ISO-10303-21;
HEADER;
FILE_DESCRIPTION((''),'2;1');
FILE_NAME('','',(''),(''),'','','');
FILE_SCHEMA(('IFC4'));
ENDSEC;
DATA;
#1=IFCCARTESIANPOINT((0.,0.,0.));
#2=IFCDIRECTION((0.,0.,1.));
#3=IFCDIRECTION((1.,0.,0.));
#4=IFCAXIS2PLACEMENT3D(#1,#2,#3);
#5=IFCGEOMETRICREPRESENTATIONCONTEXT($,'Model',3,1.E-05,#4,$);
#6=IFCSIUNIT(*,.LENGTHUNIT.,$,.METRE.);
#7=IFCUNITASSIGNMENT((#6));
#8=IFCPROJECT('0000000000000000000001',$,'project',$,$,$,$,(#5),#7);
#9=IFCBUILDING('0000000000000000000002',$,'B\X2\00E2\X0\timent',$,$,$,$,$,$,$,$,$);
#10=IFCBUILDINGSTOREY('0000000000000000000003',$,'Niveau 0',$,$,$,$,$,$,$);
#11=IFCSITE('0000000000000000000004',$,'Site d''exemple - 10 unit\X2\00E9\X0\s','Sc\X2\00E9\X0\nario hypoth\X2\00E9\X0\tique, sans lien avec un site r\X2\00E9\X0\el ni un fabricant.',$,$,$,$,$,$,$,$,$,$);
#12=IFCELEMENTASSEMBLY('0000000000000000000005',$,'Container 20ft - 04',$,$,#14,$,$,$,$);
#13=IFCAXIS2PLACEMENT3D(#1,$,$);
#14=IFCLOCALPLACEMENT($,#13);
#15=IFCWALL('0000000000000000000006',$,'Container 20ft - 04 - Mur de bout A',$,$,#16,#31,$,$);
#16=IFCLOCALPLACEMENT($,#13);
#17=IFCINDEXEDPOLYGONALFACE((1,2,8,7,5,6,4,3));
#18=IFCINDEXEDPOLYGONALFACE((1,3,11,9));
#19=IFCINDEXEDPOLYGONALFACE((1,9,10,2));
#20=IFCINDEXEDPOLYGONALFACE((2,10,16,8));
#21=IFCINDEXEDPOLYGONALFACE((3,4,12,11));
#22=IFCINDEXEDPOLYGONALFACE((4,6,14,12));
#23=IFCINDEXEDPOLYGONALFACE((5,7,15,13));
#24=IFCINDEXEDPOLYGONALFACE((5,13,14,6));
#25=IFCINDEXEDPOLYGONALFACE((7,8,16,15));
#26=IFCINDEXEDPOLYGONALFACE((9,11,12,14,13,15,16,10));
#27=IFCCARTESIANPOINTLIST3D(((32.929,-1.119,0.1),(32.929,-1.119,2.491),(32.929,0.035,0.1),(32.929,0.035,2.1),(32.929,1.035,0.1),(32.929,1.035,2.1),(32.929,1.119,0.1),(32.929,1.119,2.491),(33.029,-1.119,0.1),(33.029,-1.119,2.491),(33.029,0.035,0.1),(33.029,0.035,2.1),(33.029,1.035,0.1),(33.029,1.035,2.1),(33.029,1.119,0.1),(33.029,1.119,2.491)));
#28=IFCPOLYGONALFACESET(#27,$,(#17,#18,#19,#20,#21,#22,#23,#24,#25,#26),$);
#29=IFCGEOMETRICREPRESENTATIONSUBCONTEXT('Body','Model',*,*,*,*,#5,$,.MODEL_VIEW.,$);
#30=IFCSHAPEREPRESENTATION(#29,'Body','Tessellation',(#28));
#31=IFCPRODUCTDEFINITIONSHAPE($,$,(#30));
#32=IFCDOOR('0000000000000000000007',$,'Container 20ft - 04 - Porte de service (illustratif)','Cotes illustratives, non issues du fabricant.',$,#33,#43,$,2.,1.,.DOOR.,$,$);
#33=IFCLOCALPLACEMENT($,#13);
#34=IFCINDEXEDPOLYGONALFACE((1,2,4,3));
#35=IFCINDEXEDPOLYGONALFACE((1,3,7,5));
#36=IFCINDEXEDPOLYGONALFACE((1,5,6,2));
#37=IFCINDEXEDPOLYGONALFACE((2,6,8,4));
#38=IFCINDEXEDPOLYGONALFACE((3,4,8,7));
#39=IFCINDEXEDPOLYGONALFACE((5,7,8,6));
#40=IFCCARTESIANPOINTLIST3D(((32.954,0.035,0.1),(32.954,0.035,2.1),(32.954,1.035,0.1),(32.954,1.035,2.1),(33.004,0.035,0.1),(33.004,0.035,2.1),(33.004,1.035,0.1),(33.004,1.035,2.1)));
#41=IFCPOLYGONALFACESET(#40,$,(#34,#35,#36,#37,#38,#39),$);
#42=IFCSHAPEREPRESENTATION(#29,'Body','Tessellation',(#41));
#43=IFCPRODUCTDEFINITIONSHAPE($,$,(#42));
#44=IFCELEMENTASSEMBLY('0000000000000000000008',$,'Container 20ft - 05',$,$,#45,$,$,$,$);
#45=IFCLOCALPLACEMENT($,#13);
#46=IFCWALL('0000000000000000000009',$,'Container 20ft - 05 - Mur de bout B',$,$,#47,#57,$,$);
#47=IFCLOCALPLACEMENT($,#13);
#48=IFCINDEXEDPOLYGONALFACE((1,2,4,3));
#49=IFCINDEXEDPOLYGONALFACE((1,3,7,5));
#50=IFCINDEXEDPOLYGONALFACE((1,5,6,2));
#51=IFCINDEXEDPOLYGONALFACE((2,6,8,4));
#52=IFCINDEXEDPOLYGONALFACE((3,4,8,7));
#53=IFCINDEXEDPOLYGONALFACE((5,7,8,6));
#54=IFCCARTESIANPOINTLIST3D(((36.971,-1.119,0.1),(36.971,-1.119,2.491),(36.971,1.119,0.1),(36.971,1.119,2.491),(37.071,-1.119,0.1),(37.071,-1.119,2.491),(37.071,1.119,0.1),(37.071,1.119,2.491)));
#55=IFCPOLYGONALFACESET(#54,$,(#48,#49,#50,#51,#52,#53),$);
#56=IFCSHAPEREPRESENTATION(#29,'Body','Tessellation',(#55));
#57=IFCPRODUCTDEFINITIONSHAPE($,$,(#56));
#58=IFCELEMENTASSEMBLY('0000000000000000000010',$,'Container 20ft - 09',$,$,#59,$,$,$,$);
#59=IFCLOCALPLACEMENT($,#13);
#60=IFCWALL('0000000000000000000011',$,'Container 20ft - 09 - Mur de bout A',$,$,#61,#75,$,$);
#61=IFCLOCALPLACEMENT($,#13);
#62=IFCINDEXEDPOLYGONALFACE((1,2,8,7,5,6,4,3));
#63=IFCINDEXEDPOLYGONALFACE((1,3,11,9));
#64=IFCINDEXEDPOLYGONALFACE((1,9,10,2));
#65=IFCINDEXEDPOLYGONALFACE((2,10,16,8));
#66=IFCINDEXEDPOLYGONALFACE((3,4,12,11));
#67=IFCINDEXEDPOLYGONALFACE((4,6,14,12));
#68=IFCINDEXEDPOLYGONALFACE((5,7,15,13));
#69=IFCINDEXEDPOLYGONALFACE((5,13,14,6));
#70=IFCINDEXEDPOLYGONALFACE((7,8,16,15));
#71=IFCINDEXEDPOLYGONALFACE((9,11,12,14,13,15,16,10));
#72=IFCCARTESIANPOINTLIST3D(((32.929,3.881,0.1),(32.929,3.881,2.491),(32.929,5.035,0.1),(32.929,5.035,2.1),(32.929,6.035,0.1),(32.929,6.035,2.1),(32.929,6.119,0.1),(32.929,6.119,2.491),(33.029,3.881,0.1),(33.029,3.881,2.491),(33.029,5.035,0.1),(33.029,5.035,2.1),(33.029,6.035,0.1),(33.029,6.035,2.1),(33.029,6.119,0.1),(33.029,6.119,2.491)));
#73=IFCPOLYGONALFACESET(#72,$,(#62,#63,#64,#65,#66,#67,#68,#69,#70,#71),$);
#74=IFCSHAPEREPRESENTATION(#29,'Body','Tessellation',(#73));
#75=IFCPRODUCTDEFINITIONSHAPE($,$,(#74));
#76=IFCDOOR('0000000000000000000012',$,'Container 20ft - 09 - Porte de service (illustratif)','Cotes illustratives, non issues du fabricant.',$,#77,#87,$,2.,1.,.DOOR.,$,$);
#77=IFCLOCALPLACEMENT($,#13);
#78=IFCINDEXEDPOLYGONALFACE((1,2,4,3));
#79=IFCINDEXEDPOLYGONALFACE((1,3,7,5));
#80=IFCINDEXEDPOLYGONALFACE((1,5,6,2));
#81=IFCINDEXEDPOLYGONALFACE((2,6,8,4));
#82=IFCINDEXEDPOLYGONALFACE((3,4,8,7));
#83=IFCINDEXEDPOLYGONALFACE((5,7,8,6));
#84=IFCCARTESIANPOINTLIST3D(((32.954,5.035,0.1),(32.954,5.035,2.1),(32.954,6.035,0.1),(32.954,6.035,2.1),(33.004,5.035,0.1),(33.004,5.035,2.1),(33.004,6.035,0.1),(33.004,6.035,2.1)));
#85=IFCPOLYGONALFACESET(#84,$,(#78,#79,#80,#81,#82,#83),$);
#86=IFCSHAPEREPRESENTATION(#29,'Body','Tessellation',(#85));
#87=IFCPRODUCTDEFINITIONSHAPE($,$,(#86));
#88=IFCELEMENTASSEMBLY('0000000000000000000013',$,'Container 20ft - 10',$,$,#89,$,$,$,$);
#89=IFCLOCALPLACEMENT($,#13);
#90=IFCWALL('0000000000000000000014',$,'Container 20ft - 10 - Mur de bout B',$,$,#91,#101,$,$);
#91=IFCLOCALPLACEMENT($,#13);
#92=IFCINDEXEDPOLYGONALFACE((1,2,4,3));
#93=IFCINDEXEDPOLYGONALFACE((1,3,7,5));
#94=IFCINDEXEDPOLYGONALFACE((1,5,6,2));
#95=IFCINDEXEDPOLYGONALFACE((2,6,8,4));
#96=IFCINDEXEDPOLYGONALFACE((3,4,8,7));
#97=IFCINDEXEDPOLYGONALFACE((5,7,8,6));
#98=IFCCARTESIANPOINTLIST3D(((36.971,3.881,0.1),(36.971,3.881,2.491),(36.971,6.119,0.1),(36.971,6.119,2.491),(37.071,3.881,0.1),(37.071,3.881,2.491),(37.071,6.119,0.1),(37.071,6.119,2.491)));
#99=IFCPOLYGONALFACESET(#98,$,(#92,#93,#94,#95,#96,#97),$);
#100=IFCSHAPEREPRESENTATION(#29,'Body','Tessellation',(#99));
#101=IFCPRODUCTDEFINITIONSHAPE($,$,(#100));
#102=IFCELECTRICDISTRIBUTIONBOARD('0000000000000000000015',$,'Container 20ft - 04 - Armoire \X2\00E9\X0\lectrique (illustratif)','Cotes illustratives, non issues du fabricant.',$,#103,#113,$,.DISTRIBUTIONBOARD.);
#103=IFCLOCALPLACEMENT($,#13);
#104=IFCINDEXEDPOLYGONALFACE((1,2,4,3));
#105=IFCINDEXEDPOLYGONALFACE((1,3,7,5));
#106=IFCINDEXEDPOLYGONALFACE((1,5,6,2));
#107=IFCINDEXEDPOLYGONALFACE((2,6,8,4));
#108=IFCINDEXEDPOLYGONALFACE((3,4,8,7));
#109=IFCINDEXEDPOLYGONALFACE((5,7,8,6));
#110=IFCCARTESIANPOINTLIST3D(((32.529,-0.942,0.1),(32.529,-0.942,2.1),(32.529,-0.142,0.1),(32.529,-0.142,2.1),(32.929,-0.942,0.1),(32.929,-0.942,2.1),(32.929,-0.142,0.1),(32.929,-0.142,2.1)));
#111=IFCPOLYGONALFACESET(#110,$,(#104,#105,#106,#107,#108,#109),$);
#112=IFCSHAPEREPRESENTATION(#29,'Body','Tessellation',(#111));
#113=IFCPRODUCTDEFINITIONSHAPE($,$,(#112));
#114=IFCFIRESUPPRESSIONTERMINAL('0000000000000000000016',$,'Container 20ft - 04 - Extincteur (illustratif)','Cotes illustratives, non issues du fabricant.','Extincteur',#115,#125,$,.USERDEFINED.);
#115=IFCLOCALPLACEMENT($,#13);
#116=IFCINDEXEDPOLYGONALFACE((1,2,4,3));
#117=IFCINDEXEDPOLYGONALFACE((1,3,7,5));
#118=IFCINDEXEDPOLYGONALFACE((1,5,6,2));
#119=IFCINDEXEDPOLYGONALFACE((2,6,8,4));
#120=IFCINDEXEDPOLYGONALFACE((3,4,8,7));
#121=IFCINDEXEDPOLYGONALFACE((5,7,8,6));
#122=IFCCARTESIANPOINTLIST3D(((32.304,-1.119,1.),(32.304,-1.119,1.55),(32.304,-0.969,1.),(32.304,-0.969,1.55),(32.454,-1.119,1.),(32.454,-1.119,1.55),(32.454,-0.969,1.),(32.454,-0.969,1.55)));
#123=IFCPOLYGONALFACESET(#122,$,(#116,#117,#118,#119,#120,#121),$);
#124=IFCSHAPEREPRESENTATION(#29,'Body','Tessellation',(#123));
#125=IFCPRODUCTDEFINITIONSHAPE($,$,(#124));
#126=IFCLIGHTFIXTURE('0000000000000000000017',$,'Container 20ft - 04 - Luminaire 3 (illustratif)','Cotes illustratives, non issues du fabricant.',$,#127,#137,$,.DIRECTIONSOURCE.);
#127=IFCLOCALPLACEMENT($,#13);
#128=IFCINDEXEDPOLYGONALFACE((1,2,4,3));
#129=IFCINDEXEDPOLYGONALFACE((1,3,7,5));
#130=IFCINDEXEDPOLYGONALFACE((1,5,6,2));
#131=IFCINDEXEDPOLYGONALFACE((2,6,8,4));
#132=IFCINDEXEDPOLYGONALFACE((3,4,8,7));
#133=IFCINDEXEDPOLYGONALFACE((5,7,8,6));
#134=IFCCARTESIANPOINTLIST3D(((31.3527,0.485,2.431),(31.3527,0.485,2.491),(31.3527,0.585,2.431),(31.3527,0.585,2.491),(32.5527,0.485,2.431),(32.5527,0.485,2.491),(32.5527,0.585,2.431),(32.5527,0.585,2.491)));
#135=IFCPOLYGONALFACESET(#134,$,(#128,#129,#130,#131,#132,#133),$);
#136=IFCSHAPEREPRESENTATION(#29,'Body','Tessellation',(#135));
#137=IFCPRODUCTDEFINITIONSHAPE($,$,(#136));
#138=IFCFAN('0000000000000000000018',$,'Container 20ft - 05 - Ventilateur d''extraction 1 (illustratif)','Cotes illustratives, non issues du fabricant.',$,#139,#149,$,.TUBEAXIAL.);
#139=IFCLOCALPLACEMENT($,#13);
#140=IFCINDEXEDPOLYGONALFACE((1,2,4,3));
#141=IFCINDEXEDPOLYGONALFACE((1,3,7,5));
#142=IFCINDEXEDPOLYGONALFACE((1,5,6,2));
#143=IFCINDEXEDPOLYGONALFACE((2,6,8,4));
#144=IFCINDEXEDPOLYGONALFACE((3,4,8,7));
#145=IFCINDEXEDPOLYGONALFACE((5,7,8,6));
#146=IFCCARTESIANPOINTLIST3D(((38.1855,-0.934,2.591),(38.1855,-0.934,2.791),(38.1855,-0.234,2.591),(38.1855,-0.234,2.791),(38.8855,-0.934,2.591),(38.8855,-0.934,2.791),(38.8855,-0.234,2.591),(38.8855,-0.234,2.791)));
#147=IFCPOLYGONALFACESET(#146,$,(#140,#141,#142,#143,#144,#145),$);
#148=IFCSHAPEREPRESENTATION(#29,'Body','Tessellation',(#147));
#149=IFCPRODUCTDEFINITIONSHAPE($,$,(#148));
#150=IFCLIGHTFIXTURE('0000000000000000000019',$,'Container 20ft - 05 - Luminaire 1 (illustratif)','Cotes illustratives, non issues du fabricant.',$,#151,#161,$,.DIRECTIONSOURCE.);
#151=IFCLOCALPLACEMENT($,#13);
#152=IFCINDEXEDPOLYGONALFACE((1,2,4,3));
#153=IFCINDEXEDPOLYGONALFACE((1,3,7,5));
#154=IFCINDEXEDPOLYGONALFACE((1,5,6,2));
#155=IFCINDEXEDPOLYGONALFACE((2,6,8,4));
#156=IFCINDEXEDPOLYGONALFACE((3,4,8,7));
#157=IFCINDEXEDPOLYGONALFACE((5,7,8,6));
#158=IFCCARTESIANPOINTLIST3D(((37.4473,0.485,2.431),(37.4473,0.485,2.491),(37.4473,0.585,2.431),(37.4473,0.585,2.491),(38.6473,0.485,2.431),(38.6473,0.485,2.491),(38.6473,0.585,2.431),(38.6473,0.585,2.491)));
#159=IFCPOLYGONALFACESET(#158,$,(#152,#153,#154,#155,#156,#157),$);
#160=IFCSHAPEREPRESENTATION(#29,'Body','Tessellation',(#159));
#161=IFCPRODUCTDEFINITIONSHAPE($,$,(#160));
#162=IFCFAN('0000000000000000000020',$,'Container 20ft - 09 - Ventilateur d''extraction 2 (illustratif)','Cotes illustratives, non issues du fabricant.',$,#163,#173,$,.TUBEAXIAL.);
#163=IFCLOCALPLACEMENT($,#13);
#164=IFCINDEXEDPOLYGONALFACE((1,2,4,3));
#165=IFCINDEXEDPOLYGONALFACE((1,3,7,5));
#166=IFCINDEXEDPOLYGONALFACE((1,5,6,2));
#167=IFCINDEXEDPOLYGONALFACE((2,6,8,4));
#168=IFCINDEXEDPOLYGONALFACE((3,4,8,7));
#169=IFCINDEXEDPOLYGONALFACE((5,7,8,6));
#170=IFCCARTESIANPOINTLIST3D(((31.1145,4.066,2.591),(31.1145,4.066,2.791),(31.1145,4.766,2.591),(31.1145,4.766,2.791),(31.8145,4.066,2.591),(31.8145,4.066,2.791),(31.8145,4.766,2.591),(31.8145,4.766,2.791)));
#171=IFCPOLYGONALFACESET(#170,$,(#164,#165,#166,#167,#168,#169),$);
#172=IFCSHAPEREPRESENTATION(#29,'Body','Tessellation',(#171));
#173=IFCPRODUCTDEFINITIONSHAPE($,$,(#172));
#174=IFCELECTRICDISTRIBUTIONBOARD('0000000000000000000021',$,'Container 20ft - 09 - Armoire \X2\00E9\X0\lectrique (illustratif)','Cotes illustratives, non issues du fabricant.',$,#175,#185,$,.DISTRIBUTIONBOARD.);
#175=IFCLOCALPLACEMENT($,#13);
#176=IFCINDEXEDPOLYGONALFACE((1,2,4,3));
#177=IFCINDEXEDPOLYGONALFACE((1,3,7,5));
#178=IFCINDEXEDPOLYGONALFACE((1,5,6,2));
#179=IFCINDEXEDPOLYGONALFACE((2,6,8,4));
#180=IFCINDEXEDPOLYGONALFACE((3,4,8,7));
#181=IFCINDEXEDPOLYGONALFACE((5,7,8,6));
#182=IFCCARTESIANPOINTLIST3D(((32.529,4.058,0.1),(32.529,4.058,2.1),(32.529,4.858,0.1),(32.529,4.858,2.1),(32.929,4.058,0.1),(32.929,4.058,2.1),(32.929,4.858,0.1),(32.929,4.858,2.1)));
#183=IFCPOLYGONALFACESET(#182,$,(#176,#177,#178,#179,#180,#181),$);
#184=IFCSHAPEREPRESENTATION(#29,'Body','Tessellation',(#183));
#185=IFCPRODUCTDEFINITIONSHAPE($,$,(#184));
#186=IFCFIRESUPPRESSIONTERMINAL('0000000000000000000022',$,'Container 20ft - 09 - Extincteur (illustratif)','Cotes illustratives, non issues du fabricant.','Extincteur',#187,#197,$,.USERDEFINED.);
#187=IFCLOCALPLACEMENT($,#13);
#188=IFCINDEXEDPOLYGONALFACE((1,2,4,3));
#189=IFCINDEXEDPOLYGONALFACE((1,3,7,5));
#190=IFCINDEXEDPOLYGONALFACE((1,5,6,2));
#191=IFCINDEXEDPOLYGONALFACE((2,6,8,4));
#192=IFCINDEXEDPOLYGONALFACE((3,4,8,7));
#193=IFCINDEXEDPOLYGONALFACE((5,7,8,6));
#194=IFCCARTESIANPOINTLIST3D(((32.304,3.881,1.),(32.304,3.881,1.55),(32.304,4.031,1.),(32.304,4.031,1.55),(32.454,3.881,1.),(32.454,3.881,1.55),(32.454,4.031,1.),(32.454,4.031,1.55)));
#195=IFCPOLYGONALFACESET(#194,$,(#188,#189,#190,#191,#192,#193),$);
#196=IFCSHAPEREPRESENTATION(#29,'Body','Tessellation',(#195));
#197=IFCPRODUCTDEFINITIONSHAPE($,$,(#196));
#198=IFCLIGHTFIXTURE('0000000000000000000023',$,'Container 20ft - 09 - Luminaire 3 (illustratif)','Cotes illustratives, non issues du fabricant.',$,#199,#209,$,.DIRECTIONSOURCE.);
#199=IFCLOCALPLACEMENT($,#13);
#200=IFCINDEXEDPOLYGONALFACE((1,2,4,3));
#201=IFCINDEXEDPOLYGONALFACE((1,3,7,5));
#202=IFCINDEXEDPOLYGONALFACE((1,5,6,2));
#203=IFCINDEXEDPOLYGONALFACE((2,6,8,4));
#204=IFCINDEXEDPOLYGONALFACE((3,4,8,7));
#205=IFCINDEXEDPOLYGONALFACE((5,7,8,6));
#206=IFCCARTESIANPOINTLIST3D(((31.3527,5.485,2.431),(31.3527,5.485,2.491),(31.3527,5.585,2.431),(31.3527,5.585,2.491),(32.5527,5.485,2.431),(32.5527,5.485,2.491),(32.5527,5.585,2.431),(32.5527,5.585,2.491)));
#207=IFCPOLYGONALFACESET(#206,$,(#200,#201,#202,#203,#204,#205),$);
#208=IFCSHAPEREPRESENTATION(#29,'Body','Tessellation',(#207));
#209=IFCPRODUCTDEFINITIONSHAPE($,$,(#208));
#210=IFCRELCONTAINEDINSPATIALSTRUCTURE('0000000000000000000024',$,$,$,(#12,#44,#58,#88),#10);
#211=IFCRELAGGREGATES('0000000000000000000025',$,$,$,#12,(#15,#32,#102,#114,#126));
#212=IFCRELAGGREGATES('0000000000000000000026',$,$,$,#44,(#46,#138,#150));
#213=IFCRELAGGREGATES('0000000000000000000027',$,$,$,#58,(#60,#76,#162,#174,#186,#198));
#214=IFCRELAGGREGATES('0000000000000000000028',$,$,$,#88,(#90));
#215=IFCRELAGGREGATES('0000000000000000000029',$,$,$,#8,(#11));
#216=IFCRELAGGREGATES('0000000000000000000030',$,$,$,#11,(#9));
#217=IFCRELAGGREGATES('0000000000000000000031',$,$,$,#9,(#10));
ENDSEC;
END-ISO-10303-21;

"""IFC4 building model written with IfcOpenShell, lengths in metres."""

from ifc_helpers import new_model, si_unit, frame, origin_with_axes, place, context, subcontext, project, spatial, rectangle, extrude, element, fill, aggregate, save


model = new_model("IFC4")

# Units and contexts
model_context = context("Model", 3, precision=1e-05, world=origin_with_axes())
body_context = subcontext(model_context, "Body", "Model", "MODEL_VIEW")
ifc_project = project(units=[si_unit("LENGTHUNIT", "METRE")], contexts=[model_context])

# Site, building, storey
site = spatial("IfcSite", under=ifc_project, Name="Site d'exemple - 10 unités", Description="Scénario hypothétique, sans lien avec un site réel ni un fabricant.")
building = spatial("IfcBuilding", under=site, Name="Bâtiment")
storey = spatial("IfcBuildingStorey", under=building, Name="Niveau 0")

# Element assembly, wall, opening, door
assembly_1 = element("IfcElementAssembly", 1, inside=storey, Name="Container 20ft - 04")
wall_1_placement = place(None, frame((32.979, 0.0, 0.1), z_axis=(0.0, 0.0, 1.0), x_axis=(1.0, 0.0, 0.0)))
wall_1 = element("IfcWall", 2, at=wall_1_placement, Name="Container 20ft - 04 - Mur de bout A", context=body_context, shape_type="SweptSolid", body=[
    extrude(rectangle(XDim=0.1, YDim=2.238), origin_with_axes(), (0.0, 0.0, 1.0), 2.391),
])
opening_1_placement = place(None, frame((32.979, 0.535, 0.1), z_axis=(0.0, 0.0, 1.0), x_axis=(1.0, 0.0, 0.0)))
opening_1 = element("IfcOpeningElement", 3, at=opening_1_placement, cuts=wall_1, PredefinedType="OPENING", context=body_context, shape_type="SweptSolid", body=[
    extrude(rectangle(XDim=0.2, YDim=1.0), origin_with_axes(), (0.0, 0.0, 1.0), 2.0),
])
door_1_placement = place(None, frame((32.979, 0.535, 0.1), z_axis=(0.0, 0.0, 1.0), x_axis=(1.0, 0.0, 0.0)))
door_1 = element("IfcDoor", 4, at=door_1_placement, Name="Container 20ft - 04 - Porte de service (illustratif)", Description="Cotes illustratives, non issues du fabricant.", OverallHeight=2.0, OverallWidth=1.0, PredefinedType="DOOR", context=body_context, shape_type="SweptSolid", body=[
    extrude(rectangle(XDim=0.05, YDim=1.0), origin_with_axes(), (0.0, 0.0, 1.0), 2.0),
])
fill(opening_1, door_1)

# Element assembly, wall
assembly_2 = element("IfcElementAssembly", 5, inside=storey, Name="Container 20ft - 05")
wall_2_placement = place(None, frame((37.021, 0.0, 0.1), z_axis=(0.0, 0.0, 1.0), x_axis=(1.0, 0.0, 0.0)))
wall_2 = element("IfcWall", 6, at=wall_2_placement, Name="Container 20ft - 05 - Mur de bout B", context=body_context, shape_type="SweptSolid", body=[
    extrude(rectangle(XDim=0.1, YDim=2.238), origin_with_axes(), (0.0, 0.0, 1.0), 2.391),
])

# Element assembly, wall, opening, door
assembly_3 = element("IfcElementAssembly", 7, inside=storey, Name="Container 20ft - 09")
wall_3_placement = place(None, frame((32.979, 5.0, 0.1), z_axis=(0.0, 0.0, 1.0), x_axis=(1.0, 0.0, 0.0)))
wall_3 = element("IfcWall", 8, at=wall_3_placement, Name="Container 20ft - 09 - Mur de bout A", context=body_context, shape_type="SweptSolid", body=[
    extrude(rectangle(XDim=0.1, YDim=2.238), origin_with_axes(), (0.0, 0.0, 1.0), 2.391),
])
opening_2_placement = place(None, frame((32.979, 5.535, 0.1), z_axis=(0.0, 0.0, 1.0), x_axis=(1.0, 0.0, 0.0)))
opening_2 = element("IfcOpeningElement", 9, at=opening_2_placement, cuts=wall_3, PredefinedType="OPENING", context=body_context, shape_type="SweptSolid", body=[
    extrude(rectangle(XDim=0.2, YDim=1.0), origin_with_axes(), (0.0, 0.0, 1.0), 2.0),
])
door_2_placement = place(None, frame((32.979, 5.535, 0.1), z_axis=(0.0, 0.0, 1.0), x_axis=(1.0, 0.0, 0.0)))
door_2 = element("IfcDoor", 10, at=door_2_placement, Name="Container 20ft - 09 - Porte de service (illustratif)", Description="Cotes illustratives, non issues du fabricant.", OverallHeight=2.0, OverallWidth=1.0, PredefinedType="DOOR", context=body_context, shape_type="SweptSolid", body=[
    extrude(rectangle(XDim=0.05, YDim=1.0), origin_with_axes(), (0.0, 0.0, 1.0), 2.0),
])
fill(opening_2, door_2)

# Element assembly, wall
assembly_4 = element("IfcElementAssembly", 11, inside=storey, Name="Container 20ft - 10")
wall_4_placement = place(None, frame((37.021, 5.0, 0.1), z_axis=(0.0, 0.0, 1.0), x_axis=(1.0, 0.0, 0.0)))
wall_4 = element("IfcWall", 12, at=wall_4_placement, Name="Container 20ft - 10 - Mur de bout B", context=body_context, shape_type="SweptSolid", body=[
    extrude(rectangle(XDim=0.1, YDim=2.238), origin_with_axes(), (0.0, 0.0, 1.0), 2.391),
])

# Electric distribution board
electric_distribution_board_1_placement = place(None, frame((32.729, -0.542, 0.1), z_axis=(0.0, 0.0, 1.0), x_axis=(1.0, 0.0, 0.0)))
electric_distribution_board_1 = element("IfcElectricDistributionBoard", 13, at=electric_distribution_board_1_placement, Name="Container 20ft - 04 - Armoire électrique (illustratif)", Description="Cotes illustratives, non issues du fabricant.", PredefinedType="DISTRIBUTIONBOARD", context=body_context, shape_type="SweptSolid", body=[
    extrude(rectangle(XDim=0.4, YDim=0.8), origin_with_axes(), (0.0, 0.0, 1.0), 2.0),
])

# Fire suppression terminal
fire_suppression_terminal_1_placement = place(None, frame((32.379, -1.044, 1.0), z_axis=(0.0, 0.0, 1.0), x_axis=(1.0, 0.0, 0.0)))
fire_suppression_terminal_1 = element("IfcFireSuppressionTerminal", 14, at=fire_suppression_terminal_1_placement, Name="Container 20ft - 04 - Extincteur (illustratif)", Description="Cotes illustratives, non issues du fabricant.", ObjectType="Extincteur", PredefinedType="USERDEFINED", context=body_context, shape_type="SweptSolid", body=[
    extrude(rectangle(XDim=0.15, YDim=0.15), origin_with_axes(), (0.0, 0.0, 1.0), 0.55),
])

# Light fixture
light_fixture_1_placement = place(None, frame((31.9527, 0.535, 2.431), z_axis=(0.0, 0.0, 1.0), x_axis=(1.0, 0.0, 0.0)))
light_fixture_1 = element("IfcLightFixture", 15, at=light_fixture_1_placement, Name="Container 20ft - 04 - Luminaire 3 (illustratif)", Description="Cotes illustratives, non issues du fabricant.", PredefinedType="DIRECTIONSOURCE", context=body_context, shape_type="SweptSolid", body=[
    extrude(rectangle(XDim=1.2, YDim=0.1), origin_with_axes(), (0.0, 0.0, 1.0), 0.06),
])

# Fan
fan_1_placement = place(None, frame((38.5355, -0.584, 2.591), z_axis=(0.0, 0.0, 1.0), x_axis=(1.0, 0.0, 0.0)))
fan_1 = element("IfcFan", 16, at=fan_1_placement, Name="Container 20ft - 05 - Ventilateur d'extraction 1 (illustratif)", Description="Cotes illustratives, non issues du fabricant.", PredefinedType="TUBEAXIAL", context=body_context, shape_type="SweptSolid", body=[
    extrude(rectangle(XDim=0.7, YDim=0.7), origin_with_axes(), (0.0, 0.0, 1.0), 0.2),
])

# Light fixture
light_fixture_2_placement = place(None, frame((38.0473, 0.535, 2.431), z_axis=(0.0, 0.0, 1.0), x_axis=(1.0, 0.0, 0.0)))
light_fixture_2 = element("IfcLightFixture", 17, at=light_fixture_2_placement, Name="Container 20ft - 05 - Luminaire 1 (illustratif)", Description="Cotes illustratives, non issues du fabricant.", PredefinedType="DIRECTIONSOURCE", context=body_context, shape_type="SweptSolid", body=[
    extrude(rectangle(XDim=1.2, YDim=0.1), origin_with_axes(), (0.0, 0.0, 1.0), 0.06),
])

# Fan
fan_2_placement = place(None, frame((31.4645, 4.416, 2.591), z_axis=(0.0, 0.0, 1.0), x_axis=(1.0, 0.0, 0.0)))
fan_2 = element("IfcFan", 18, at=fan_2_placement, Name="Container 20ft - 09 - Ventilateur d'extraction 2 (illustratif)", Description="Cotes illustratives, non issues du fabricant.", PredefinedType="TUBEAXIAL", context=body_context, shape_type="SweptSolid", body=[
    extrude(rectangle(XDim=0.7, YDim=0.7), origin_with_axes(), (0.0, 0.0, 1.0), 0.2),
])

# Electric distribution board
electric_distribution_board_2_placement = place(None, frame((32.729, 4.458, 0.1), z_axis=(0.0, 0.0, 1.0), x_axis=(1.0, 0.0, 0.0)))
electric_distribution_board_2 = element("IfcElectricDistributionBoard", 19, at=electric_distribution_board_2_placement, Name="Container 20ft - 09 - Armoire électrique (illustratif)", Description="Cotes illustratives, non issues du fabricant.", PredefinedType="DISTRIBUTIONBOARD", context=body_context, shape_type="SweptSolid", body=[
    extrude(rectangle(XDim=0.4, YDim=0.8), origin_with_axes(), (0.0, 0.0, 1.0), 2.0),
])

# Fire suppression terminal
fire_suppression_terminal_2_placement = place(None, frame((32.379, 3.956, 1.0), z_axis=(0.0, 0.0, 1.0), x_axis=(1.0, 0.0, 0.0)))
fire_suppression_terminal_2 = element("IfcFireSuppressionTerminal", 20, at=fire_suppression_terminal_2_placement, Name="Container 20ft - 09 - Extincteur (illustratif)", Description="Cotes illustratives, non issues du fabricant.", ObjectType="Extincteur", PredefinedType="USERDEFINED", context=body_context, shape_type="SweptSolid", body=[
    extrude(rectangle(XDim=0.15, YDim=0.15), origin_with_axes(), (0.0, 0.0, 1.0), 0.55),
])

# Light fixture
light_fixture_3_placement = place(None, frame((31.9527, 5.535, 2.431), z_axis=(0.0, 0.0, 1.0), x_axis=(1.0, 0.0, 0.0)))
light_fixture_3 = element("IfcLightFixture", 21, at=light_fixture_3_placement, Name="Container 20ft - 09 - Luminaire 3 (illustratif)", Description="Cotes illustratives, non issues du fabricant.", PredefinedType="DIRECTIONSOURCE", context=body_context, shape_type="SweptSolid", body=[
    extrude(rectangle(XDim=1.2, YDim=0.1), origin_with_axes(), (0.0, 0.0, 1.0), 0.06),
])

aggregate(assembly_1, [wall_1, door_1, electric_distribution_board_1, fire_suppression_terminal_1, light_fixture_1])
aggregate(assembly_2, [wall_2, fan_1, light_fixture_2])
aggregate(assembly_3, [wall_3, door_2, fan_2, electric_distribution_board_2, fire_suppression_terminal_2, light_fixture_3])
aggregate(assembly_4, [wall_4])

save(model, "model.ifc")
